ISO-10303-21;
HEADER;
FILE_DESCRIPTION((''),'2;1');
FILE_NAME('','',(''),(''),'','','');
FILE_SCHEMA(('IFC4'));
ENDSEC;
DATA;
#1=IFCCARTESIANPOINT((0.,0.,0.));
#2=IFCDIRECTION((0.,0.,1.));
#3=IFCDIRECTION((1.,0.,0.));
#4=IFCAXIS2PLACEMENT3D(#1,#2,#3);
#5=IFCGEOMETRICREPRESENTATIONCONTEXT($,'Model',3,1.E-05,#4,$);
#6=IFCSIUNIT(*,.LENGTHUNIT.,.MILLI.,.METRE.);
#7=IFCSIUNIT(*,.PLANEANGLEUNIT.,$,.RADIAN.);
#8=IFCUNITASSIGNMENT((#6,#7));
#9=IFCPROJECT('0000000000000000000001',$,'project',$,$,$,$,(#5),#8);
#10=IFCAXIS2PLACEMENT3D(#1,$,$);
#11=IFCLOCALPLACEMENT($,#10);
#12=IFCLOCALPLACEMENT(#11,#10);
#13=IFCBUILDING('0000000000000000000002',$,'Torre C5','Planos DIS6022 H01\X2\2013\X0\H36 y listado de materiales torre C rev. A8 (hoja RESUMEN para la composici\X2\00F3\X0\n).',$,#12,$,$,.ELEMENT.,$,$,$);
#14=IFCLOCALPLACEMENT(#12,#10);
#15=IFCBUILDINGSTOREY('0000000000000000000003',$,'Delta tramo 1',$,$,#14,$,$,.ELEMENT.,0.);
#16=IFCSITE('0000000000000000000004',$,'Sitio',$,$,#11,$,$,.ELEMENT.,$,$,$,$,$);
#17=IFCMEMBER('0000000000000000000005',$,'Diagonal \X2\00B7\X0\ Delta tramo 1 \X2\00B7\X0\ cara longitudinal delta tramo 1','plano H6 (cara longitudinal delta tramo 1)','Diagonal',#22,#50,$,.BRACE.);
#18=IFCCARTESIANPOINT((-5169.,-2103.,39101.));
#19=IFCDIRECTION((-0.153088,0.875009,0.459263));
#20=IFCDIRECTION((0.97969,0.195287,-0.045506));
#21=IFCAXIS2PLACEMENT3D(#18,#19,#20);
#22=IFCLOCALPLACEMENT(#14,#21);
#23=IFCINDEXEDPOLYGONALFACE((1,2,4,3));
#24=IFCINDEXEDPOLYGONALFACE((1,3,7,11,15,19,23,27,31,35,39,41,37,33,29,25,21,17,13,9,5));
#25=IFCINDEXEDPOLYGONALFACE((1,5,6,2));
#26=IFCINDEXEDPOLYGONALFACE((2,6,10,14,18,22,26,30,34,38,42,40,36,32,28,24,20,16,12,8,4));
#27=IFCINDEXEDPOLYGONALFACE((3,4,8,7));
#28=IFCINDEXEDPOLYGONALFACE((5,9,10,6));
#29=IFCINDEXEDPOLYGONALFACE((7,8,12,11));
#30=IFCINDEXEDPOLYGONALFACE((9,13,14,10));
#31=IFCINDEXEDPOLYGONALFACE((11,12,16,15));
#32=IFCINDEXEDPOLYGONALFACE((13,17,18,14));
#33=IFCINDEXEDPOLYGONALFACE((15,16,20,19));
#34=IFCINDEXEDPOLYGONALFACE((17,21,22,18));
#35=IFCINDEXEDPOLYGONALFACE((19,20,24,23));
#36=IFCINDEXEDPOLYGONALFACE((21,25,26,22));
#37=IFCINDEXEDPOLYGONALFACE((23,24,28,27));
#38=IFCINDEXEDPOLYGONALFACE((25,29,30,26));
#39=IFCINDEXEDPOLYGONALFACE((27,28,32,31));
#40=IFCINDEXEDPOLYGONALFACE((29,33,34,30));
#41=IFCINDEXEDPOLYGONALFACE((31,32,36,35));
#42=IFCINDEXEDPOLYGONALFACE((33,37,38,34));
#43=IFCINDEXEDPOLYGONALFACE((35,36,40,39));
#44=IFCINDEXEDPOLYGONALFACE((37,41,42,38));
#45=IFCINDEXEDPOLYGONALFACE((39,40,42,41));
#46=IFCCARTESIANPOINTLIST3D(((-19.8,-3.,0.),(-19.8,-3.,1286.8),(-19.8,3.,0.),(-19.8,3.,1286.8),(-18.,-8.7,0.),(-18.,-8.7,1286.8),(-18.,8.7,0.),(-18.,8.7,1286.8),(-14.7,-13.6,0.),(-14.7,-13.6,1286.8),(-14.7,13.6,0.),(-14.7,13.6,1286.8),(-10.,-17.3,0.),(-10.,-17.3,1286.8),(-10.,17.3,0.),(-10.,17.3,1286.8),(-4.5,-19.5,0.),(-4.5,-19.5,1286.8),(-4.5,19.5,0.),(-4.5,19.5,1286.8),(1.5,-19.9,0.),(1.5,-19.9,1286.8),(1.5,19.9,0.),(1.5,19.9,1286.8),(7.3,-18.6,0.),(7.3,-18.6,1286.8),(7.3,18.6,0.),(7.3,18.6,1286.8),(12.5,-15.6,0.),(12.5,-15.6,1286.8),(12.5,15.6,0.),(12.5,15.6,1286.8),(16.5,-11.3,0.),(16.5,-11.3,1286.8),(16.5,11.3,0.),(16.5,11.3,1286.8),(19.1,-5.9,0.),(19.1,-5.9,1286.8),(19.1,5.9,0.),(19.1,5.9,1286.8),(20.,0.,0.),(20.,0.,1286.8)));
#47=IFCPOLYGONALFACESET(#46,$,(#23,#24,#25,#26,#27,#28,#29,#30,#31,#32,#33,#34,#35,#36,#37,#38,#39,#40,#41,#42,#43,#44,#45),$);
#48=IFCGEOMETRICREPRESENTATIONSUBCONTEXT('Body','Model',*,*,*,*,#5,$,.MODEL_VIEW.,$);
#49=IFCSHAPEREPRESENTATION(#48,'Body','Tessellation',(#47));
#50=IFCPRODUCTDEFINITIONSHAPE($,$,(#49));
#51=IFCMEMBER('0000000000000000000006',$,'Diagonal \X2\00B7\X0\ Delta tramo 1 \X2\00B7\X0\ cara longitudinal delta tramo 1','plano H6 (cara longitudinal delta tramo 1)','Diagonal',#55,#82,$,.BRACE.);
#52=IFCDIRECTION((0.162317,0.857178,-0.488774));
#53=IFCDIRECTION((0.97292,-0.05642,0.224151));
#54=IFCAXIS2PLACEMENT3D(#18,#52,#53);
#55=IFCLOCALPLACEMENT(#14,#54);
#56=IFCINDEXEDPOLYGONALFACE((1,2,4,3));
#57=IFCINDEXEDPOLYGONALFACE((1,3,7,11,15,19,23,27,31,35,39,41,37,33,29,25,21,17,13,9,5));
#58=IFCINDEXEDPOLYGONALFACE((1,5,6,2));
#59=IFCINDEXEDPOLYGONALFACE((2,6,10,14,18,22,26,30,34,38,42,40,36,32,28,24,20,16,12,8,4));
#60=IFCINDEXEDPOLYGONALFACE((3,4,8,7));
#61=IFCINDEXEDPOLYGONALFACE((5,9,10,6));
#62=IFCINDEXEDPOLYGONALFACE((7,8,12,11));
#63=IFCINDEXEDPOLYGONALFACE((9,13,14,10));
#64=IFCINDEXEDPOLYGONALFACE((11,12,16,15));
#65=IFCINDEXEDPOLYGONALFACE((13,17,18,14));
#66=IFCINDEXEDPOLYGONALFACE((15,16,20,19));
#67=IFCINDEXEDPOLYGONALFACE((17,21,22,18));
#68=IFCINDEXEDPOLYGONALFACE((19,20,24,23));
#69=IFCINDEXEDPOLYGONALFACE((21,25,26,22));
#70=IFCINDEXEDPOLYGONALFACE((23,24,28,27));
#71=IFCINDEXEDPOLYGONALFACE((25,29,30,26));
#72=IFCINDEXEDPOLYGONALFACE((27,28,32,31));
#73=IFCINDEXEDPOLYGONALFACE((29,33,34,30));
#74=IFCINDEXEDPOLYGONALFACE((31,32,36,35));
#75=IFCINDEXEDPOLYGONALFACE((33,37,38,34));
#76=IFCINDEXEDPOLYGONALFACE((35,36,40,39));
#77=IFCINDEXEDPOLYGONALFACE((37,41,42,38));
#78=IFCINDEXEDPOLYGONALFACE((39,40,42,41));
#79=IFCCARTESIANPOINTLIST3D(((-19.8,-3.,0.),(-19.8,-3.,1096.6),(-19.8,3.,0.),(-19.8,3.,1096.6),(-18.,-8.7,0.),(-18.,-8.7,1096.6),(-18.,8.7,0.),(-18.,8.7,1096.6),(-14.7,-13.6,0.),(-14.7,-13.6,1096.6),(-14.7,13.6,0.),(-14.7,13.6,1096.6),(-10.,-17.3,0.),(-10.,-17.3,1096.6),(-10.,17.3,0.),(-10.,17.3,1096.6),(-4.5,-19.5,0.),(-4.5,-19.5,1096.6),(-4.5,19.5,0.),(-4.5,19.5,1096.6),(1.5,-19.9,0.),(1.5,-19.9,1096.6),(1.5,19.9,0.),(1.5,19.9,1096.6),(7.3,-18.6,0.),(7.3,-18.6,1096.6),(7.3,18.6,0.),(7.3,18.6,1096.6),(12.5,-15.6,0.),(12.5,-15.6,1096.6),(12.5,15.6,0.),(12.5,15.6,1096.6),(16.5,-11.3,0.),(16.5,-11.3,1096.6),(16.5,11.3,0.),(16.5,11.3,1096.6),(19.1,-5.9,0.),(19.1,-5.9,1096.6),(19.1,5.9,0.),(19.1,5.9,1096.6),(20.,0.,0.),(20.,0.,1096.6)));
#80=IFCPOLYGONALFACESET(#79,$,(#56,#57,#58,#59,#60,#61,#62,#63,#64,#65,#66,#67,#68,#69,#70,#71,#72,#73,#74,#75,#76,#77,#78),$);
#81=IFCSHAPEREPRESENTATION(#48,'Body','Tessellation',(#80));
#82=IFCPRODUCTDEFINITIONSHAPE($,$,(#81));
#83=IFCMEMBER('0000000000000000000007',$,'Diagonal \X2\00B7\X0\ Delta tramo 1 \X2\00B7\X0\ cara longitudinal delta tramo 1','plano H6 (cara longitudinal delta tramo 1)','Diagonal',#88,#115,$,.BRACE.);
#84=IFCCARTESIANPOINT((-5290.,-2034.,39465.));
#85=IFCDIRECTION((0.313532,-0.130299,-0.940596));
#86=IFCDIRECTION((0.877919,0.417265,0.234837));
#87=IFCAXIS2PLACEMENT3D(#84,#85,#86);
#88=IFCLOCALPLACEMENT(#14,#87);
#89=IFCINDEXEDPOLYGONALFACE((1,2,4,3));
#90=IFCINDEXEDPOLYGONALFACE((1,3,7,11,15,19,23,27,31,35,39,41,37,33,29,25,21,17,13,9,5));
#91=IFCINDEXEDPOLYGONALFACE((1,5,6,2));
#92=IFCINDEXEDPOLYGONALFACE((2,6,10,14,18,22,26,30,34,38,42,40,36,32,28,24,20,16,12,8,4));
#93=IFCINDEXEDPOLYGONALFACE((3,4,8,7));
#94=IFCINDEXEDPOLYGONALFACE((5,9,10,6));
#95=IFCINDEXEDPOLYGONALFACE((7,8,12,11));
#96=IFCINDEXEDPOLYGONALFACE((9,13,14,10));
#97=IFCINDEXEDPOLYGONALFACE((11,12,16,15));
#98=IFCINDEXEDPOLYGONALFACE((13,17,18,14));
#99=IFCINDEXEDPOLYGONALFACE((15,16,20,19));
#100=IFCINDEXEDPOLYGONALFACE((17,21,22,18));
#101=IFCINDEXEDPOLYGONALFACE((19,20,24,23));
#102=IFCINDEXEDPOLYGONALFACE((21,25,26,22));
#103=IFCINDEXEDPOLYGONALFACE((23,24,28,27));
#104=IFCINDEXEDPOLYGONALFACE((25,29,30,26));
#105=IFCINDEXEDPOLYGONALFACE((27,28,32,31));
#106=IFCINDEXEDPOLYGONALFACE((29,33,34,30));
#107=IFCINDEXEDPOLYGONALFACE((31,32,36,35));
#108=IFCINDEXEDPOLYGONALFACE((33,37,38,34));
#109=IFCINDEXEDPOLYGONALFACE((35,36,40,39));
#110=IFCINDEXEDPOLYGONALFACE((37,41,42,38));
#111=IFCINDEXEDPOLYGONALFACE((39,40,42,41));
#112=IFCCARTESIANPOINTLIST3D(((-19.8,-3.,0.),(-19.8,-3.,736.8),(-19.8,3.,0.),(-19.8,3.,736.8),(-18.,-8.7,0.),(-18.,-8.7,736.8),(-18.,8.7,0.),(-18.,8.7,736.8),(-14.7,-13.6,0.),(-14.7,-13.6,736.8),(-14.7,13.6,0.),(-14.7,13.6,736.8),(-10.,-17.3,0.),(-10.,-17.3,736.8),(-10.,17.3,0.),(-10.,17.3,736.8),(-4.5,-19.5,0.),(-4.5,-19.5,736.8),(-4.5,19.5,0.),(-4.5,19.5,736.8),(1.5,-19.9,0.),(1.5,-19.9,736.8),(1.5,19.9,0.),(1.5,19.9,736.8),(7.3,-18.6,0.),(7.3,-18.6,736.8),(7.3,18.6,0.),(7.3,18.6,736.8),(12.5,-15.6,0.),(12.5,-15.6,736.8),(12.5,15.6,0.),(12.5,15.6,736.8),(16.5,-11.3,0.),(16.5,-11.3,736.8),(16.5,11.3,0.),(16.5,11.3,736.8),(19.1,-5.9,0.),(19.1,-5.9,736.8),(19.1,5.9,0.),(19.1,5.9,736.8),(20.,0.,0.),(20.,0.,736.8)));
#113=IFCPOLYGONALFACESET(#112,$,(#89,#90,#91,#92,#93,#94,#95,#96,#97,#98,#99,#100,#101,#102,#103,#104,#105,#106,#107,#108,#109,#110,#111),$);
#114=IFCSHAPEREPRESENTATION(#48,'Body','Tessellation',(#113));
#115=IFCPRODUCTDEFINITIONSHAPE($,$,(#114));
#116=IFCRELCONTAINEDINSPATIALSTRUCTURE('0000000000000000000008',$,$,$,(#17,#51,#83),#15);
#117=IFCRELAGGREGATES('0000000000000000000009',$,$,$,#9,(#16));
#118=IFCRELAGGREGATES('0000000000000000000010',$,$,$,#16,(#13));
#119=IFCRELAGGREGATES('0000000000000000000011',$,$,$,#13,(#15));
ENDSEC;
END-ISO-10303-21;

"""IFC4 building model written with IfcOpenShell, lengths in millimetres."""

from ifc_helpers import new_model, si_unit, frame, origin, origin_with_axes, place, context, subcontext, project, spatial, circle, extrude, element, save


model = new_model("IFC4")

# Units and contexts
model_context = context("Model", 3, precision=1e-05, world=origin_with_axes())
body_context = subcontext(model_context, "Body", "Model", "MODEL_VIEW")
ifc_project = project(units=[si_unit("LENGTHUNIT", "METRE", prefix="MILLI"), si_unit("PLANEANGLEUNIT", "RADIAN")], contexts=[model_context])

# Site, building, storey
site_placement = place(None, origin())
site = spatial("IfcSite", under=ifc_project, at=site_placement, Name="Sitio", CompositionType="ELEMENT")
building_placement = place(site_placement, origin())
building = spatial("IfcBuilding", under=site, at=building_placement, Name="Torre C5", Description="Planos DIS6022 H01–H36 y listado de materiales torre C rev. A8 (hoja RESUMEN para la composición).", CompositionType="ELEMENT")
storey_placement = place(building_placement, origin())
storey = spatial("IfcBuildingStorey", under=building, at=storey_placement, Name="Delta tramo 1", CompositionType="ELEMENT", Elevation=0.0)

# Members
member_1_placement = place(storey_placement, frame((-5169.0, -2103.0, 39101.0), z_axis=(-0.153088, 0.875009, 0.459263), x_axis=(0.97969, 0.195287, -0.045506)))
element("IfcMember", 1, at=member_1_placement, inside=storey, Name="Diagonal · Delta tramo 1 · cara longitudinal delta tramo 1", Description="plano H6 (cara longitudinal delta tramo 1)", ObjectType="Diagonal", PredefinedType="BRACE", context=body_context, shape_type="SweptSolid", body=[
    extrude(circle(Radius=20.0), None, (0.0, 0.0, 1.0), 1286.8),
])
member_2_placement = place(storey_placement, frame((-5169.0, -2103.0, 39101.0), z_axis=(0.162317, 0.857178, -0.488774), x_axis=(0.97292, -0.05642, 0.224151)))
element("IfcMember", 2, at=member_2_placement, inside=storey, Name="Diagonal · Delta tramo 1 · cara longitudinal delta tramo 1", Description="plano H6 (cara longitudinal delta tramo 1)", ObjectType="Diagonal", PredefinedType="BRACE", context=body_context, shape_type="SweptSolid", body=[
    extrude(circle(Radius=20.0), None, (0.0, 0.0, 1.0), 1096.6),
])
member_3_placement = place(storey_placement, frame((-5290.0, -2034.0, 39465.0), z_axis=(0.313532, -0.130299, -0.940596), x_axis=(0.877919, 0.417265, 0.234837)))
element("IfcMember", 3, at=member_3_placement, inside=storey, Name="Diagonal · Delta tramo 1 · cara longitudinal delta tramo 1", Description="plano H6 (cara longitudinal delta tramo 1)", ObjectType="Diagonal", PredefinedType="BRACE", context=body_context, shape_type="SweptSolid", body=[
    extrude(circle(Radius=20.0), None, (0.0, 0.0, 1.0), 736.8),
])

save(model, "model.ifc")
